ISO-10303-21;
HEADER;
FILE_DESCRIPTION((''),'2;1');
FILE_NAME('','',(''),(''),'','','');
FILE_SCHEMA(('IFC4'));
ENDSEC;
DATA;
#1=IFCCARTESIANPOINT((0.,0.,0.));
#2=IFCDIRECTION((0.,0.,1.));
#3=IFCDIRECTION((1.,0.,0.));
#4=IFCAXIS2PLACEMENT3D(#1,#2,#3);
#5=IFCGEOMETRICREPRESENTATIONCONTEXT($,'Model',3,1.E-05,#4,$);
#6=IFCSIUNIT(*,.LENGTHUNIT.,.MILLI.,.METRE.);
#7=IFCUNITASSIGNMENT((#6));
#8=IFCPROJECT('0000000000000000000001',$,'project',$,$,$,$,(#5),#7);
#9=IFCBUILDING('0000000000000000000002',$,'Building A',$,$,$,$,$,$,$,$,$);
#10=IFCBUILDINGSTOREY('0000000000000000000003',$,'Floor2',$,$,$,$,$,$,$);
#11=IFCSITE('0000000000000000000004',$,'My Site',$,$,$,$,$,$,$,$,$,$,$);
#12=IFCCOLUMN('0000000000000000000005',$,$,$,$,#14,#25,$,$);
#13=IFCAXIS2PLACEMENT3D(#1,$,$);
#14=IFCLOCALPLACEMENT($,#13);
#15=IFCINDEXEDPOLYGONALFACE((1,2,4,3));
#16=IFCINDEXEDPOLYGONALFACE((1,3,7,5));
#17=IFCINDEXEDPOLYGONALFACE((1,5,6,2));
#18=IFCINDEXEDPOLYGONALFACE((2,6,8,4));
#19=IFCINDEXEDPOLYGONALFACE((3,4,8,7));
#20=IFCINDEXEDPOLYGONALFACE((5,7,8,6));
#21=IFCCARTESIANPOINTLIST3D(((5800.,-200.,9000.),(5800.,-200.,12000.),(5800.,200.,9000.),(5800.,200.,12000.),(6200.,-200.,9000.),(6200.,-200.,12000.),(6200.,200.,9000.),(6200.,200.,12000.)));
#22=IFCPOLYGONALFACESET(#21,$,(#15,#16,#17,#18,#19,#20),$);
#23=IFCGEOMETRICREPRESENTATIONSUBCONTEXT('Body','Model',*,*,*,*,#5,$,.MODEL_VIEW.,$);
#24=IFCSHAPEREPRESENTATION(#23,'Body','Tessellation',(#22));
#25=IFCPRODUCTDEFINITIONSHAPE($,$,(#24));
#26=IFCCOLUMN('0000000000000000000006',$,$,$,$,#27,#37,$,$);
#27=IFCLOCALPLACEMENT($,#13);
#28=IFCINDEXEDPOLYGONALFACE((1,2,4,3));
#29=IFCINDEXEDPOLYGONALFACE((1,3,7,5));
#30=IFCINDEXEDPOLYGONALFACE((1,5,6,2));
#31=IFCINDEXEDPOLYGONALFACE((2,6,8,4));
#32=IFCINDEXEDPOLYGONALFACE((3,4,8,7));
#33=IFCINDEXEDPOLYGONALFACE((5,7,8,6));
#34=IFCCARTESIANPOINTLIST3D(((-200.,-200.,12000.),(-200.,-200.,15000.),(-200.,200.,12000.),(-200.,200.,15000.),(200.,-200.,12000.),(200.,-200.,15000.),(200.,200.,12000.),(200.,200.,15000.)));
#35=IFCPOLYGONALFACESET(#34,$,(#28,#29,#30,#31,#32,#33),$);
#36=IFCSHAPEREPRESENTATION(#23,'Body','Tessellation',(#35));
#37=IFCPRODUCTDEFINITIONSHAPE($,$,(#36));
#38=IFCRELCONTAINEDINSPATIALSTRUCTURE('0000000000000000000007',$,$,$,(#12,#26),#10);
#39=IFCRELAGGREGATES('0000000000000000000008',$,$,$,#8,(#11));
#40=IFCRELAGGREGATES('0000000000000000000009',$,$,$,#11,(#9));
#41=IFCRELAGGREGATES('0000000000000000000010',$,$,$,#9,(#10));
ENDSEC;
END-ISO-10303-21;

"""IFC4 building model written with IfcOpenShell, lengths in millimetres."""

from ifc_helpers import new_model, si_unit, frame, origin_with_axes, place, context, subcontext, project, spatial, line, indexed_curve, outline, extrude, element, save


model = new_model("IFC4")

# Units and contexts
model_context = context("Model", 3, precision=1e-05, world=origin_with_axes())
body_context = subcontext(model_context, "Body", "Model", "MODEL_VIEW")
ifc_project = project(units=[si_unit("LENGTHUNIT", "METRE", prefix="MILLI")], contexts=[model_context])

# Site, building, storey
site = spatial("IfcSite", under=ifc_project, Name="My Site")
building = spatial("IfcBuilding", under=site, Name="Building A")
storey = spatial("IfcBuildingStorey", under=building, Name="Floor2")

# Columns
for number, where, z_axis, x_axis in (
    (1, (6000.0, 0.0, 9000.0), (0.0, 0.0, 1.0), (1.0, 0.0, 0.0)),
    (2, (0.0, 0.0, 12000.0), (0.0, 0.0, 1.0), (1.0, 0.0, 0.0)),
):
    element("IfcColumn", number, at=place(None, frame(where, z_axis=z_axis, x_axis=x_axis)), inside=storey, context=body_context, shape_type="SweptSolid", body=[
        extrude(outline(indexed_curve([(-200.0, -200.0), (200.0, -200.0), (200.0, 200.0), (-200.0, 200.0)], segments=[line(1, 2, 3, 4, 1)])), origin_with_axes(), (0.0, 0.0, 1.0), 3000.0),
    ])

save(model, "model.ifc")
